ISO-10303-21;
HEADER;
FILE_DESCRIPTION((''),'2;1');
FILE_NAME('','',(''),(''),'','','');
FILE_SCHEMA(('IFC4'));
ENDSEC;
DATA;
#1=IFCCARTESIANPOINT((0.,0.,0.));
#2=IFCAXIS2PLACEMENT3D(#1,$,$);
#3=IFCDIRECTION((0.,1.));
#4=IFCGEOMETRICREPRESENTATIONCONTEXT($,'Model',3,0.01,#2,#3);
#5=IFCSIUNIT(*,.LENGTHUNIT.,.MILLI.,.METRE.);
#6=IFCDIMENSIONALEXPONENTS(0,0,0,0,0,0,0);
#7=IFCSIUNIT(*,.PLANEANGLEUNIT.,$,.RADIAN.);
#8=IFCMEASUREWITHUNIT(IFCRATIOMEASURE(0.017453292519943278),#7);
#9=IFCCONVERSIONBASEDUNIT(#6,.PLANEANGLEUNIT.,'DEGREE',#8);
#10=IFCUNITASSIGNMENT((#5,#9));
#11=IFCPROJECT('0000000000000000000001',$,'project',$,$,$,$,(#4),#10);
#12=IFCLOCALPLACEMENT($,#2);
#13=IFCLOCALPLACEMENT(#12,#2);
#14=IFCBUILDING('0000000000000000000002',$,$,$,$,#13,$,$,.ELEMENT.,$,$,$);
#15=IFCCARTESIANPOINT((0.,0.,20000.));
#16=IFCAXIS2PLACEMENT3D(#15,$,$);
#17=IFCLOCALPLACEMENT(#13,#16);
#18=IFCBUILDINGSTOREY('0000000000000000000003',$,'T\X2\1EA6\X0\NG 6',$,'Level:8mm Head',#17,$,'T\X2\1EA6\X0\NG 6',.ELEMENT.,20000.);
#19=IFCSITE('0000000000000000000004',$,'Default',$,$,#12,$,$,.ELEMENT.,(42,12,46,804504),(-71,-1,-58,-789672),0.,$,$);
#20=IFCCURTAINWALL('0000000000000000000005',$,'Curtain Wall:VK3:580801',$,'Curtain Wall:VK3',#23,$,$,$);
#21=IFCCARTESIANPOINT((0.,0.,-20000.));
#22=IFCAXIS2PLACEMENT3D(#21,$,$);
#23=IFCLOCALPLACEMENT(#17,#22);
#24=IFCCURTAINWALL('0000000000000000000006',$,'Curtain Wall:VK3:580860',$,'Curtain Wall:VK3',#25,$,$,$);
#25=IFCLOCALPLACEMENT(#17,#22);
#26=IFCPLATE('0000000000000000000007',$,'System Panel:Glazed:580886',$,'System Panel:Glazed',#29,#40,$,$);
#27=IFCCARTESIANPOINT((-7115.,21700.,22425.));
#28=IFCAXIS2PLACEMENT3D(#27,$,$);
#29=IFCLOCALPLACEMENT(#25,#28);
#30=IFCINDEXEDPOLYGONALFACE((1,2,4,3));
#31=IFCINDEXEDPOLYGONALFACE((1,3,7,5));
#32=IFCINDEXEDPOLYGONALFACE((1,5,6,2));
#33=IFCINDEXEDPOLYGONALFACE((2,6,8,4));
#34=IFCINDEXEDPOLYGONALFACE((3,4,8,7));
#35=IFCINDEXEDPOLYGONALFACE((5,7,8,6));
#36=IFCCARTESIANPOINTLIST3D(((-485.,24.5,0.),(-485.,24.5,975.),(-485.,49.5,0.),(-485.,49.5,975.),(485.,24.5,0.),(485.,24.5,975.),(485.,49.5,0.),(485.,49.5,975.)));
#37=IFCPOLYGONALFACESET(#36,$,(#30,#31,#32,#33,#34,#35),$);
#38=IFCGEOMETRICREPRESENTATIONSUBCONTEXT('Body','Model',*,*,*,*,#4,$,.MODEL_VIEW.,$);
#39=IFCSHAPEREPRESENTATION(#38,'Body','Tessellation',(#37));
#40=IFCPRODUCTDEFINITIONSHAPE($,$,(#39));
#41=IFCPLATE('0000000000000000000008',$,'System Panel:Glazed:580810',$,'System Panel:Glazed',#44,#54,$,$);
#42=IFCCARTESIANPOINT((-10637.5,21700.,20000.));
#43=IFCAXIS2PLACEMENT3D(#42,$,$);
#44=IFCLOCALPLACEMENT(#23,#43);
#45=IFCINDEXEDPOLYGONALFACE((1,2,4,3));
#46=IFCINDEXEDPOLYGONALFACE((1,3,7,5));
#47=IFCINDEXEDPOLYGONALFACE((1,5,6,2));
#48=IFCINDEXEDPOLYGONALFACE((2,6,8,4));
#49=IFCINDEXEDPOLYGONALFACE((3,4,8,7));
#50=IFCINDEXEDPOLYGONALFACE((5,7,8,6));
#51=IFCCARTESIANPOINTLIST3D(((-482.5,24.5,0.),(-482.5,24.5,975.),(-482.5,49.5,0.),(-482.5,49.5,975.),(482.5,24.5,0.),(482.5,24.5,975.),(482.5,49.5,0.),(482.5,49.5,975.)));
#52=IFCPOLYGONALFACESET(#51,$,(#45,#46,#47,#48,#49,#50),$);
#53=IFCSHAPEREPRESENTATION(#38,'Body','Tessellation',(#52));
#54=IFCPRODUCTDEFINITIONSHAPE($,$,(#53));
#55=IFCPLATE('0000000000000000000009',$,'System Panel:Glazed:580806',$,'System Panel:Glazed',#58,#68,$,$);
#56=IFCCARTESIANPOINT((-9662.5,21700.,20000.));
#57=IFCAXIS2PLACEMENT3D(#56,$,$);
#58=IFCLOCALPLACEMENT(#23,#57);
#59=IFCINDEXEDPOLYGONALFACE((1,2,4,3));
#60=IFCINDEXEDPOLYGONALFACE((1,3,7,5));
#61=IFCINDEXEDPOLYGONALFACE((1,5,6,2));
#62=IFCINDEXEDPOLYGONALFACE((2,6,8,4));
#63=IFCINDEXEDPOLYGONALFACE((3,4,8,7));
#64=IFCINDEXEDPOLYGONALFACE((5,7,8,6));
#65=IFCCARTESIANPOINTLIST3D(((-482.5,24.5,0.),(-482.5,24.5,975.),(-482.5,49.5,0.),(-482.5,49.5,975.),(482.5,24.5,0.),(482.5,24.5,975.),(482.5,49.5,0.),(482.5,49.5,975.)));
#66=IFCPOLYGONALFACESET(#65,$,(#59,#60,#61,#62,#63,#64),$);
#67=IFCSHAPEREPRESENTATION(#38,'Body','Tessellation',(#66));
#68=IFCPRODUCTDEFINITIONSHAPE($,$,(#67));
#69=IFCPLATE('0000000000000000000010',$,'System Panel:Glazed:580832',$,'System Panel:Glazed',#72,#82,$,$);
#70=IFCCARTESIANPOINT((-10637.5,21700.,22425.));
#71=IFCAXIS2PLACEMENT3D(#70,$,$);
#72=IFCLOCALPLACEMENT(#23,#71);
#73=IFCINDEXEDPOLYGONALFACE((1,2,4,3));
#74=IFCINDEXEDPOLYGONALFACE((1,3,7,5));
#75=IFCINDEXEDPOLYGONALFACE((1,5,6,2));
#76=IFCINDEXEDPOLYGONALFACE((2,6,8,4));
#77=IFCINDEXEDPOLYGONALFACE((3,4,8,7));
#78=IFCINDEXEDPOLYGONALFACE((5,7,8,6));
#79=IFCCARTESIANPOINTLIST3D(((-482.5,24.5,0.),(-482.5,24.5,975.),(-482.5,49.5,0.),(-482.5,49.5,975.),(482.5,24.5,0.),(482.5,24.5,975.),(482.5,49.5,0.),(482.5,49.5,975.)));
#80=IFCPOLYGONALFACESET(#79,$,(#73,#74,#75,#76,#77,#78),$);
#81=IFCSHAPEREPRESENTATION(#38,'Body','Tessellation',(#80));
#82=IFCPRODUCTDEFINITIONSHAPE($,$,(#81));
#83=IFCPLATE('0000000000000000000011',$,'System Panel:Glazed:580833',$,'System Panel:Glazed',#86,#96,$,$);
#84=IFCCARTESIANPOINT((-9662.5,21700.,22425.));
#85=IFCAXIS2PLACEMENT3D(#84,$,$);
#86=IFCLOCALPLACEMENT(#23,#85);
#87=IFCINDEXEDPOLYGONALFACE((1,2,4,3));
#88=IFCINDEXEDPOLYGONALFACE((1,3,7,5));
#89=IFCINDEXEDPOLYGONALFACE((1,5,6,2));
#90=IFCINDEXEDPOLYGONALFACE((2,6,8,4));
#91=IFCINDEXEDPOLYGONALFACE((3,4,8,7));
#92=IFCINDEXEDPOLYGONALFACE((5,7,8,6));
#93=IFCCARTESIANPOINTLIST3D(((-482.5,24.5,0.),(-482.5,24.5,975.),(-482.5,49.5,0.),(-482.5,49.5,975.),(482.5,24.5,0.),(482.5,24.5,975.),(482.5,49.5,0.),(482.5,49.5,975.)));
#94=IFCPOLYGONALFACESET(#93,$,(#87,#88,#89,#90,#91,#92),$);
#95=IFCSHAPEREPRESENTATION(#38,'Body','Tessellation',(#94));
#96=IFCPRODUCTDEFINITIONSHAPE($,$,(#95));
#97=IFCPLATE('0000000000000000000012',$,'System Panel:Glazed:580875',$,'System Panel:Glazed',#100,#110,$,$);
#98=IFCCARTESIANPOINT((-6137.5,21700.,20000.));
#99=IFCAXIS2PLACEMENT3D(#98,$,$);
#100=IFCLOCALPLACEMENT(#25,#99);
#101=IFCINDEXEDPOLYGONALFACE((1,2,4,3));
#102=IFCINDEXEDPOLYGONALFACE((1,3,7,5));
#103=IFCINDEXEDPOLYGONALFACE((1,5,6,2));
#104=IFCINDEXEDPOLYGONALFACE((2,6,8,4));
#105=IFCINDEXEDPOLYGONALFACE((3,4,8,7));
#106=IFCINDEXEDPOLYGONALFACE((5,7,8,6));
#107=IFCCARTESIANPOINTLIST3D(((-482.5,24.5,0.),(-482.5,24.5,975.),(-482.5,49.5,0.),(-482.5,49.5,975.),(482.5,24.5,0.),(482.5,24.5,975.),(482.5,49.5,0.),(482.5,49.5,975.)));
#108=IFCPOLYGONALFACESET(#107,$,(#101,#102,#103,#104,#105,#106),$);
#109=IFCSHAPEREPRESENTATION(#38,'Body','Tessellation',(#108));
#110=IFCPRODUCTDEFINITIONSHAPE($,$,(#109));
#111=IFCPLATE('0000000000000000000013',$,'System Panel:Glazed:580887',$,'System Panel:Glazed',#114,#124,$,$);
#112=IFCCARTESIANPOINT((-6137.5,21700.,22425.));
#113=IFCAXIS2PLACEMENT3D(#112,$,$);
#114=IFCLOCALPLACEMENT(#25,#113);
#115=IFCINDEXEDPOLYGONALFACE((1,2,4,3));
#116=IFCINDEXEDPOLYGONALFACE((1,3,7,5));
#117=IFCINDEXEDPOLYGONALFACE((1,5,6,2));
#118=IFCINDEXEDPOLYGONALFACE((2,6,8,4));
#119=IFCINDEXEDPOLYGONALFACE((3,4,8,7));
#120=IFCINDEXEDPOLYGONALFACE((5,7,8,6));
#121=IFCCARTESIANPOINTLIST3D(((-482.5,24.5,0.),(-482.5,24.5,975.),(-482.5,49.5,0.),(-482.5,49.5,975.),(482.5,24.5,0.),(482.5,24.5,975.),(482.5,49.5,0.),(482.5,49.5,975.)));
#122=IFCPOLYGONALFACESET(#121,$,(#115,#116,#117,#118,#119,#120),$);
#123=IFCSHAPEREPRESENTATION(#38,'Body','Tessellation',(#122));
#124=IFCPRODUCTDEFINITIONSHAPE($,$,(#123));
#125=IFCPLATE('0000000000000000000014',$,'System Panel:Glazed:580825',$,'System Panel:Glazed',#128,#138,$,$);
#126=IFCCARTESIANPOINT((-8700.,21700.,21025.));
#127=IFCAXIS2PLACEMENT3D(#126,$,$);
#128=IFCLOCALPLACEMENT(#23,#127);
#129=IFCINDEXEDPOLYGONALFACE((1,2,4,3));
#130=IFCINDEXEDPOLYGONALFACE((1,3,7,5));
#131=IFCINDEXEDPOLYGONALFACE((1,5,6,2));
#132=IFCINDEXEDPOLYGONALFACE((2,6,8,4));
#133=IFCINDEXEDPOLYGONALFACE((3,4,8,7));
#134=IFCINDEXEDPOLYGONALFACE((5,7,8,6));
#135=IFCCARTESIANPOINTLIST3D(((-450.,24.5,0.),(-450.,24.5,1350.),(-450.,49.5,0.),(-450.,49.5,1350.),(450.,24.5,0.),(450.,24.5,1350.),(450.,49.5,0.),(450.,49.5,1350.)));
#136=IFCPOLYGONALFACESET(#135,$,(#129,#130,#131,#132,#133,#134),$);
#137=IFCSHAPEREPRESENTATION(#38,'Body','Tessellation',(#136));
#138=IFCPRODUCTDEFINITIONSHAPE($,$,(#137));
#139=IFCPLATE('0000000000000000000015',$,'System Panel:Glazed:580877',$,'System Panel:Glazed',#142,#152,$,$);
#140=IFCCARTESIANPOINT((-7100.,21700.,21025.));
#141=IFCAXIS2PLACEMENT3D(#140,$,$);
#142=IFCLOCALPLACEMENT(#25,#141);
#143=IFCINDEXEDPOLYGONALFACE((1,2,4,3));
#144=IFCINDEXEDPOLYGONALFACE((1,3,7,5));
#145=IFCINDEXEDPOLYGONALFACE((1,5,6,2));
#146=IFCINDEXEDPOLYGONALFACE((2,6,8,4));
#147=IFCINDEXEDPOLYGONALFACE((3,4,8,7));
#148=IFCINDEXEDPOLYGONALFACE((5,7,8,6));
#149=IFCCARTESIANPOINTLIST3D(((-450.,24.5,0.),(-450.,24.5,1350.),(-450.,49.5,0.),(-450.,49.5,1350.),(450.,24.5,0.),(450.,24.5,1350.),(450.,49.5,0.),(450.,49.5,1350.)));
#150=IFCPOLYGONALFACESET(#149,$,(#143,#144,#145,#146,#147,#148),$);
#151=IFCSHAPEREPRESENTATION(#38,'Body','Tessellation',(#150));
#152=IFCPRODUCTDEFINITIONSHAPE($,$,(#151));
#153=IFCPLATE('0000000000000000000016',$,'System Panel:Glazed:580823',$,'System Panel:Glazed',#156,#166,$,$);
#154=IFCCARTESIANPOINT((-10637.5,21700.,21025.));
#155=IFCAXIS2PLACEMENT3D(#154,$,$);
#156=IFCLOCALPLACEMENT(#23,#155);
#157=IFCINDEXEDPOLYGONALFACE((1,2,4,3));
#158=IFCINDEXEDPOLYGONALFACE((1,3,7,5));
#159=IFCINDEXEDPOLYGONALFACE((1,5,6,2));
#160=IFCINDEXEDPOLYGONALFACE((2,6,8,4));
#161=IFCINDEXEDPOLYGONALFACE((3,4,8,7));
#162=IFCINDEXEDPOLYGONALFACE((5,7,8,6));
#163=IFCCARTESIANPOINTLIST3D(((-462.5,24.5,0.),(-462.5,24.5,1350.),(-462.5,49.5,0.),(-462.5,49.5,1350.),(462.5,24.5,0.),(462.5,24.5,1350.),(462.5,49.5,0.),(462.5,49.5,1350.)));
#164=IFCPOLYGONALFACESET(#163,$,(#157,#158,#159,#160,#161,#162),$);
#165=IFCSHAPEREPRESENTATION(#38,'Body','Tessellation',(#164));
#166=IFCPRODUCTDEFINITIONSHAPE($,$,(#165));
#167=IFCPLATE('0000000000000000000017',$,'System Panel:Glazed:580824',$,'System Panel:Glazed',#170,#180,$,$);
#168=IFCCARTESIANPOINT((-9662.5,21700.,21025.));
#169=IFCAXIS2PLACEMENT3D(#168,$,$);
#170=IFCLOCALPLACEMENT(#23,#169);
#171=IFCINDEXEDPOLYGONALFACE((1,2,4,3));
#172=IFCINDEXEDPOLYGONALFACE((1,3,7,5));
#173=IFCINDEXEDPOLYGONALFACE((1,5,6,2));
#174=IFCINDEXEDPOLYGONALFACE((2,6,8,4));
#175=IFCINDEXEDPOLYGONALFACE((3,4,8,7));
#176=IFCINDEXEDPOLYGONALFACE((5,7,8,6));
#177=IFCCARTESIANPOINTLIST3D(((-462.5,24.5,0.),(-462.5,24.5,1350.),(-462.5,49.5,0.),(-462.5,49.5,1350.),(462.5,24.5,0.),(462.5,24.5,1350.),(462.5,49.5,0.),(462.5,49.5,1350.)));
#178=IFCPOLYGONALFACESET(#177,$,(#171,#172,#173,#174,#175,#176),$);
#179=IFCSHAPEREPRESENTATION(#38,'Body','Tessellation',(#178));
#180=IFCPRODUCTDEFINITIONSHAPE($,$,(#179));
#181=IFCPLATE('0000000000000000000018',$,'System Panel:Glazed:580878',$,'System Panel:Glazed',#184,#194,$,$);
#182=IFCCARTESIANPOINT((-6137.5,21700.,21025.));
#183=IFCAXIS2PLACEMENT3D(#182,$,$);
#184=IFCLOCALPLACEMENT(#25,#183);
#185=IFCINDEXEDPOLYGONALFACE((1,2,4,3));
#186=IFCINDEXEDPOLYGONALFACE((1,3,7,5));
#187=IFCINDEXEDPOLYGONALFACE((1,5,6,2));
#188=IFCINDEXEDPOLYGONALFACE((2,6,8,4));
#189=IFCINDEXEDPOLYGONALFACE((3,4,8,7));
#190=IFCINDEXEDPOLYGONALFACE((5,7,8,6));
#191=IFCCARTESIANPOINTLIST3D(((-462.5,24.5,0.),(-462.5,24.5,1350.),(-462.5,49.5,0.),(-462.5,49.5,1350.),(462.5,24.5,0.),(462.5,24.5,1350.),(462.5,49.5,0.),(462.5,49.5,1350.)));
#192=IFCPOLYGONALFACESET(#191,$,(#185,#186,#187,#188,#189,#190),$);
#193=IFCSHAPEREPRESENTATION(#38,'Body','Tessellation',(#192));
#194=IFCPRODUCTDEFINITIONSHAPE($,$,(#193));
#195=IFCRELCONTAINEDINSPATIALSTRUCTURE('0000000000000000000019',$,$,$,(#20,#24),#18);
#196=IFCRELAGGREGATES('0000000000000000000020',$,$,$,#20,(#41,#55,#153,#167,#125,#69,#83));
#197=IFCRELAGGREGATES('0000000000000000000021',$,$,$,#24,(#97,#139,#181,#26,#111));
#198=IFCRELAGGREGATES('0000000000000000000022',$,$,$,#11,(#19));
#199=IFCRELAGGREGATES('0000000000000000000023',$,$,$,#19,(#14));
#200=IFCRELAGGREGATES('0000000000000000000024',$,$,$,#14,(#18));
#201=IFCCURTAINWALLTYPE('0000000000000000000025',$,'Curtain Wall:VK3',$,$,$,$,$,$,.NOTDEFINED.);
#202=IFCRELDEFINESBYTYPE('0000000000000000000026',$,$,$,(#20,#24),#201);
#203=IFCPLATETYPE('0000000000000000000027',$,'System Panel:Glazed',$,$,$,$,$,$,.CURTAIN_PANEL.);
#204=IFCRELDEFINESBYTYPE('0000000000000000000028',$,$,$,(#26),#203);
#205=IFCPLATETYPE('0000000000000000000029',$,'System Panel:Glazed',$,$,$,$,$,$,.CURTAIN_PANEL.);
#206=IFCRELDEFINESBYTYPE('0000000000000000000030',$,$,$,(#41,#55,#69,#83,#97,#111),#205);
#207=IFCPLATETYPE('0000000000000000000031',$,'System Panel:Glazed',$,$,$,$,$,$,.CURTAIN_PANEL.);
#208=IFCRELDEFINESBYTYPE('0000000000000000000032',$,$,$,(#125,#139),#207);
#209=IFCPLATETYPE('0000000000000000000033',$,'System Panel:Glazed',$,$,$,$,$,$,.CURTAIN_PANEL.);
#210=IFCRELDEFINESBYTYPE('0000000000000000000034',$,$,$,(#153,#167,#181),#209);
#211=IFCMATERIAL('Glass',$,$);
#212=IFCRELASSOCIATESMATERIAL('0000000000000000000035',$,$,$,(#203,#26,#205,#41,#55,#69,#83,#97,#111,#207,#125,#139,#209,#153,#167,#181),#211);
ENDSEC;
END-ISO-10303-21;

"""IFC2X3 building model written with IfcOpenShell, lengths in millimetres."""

from ifc_helpers import new_model, entity, si_unit, converted_unit, direction, frame, origin, origin_2d_with_axis, place, context, subcontext, project, spatial, rectangle, extrude, source, transform, mapped, material, type_object, type_shapes, element, aggregate, save


model = new_model("IFC2X3")

# Units and contexts
model_context = context("Model", 3, precision=0.01, world=origin(), true_north=direction((0.0, 1.0)))
body_context = subcontext(model_context, "Body", "Model", "MODEL_VIEW")
ifc_project = project(units=[si_unit("LENGTHUNIT", "METRE", prefix="MILLI"), converted_unit("PLANEANGLEUNIT", "DEGREE", entity("IfcRatioMeasure", 0.017453292519943278), si_unit("PLANEANGLEUNIT", "RADIAN"), dimensions=[0, 0, 0, 0, 0, 0, 0])], contexts=[model_context])

# Site, building, storey
site_placement = place(None, origin())
site = spatial("IfcSite", under=ifc_project, at=site_placement, Name="Default", CompositionType="ELEMENT", RefLatitude=(42, 12, 46, 804504), RefLongitude=(-71, -1, -58, -789672), RefElevation=0.0)
building_placement = place(site_placement, origin())
building = spatial("IfcBuilding", under=site, at=building_placement, CompositionType="ELEMENT")
storey_placement = place(building_placement, frame((0.0, 0.0, 20000.0)))
storey = spatial("IfcBuildingStorey", under=building, at=storey_placement, Name="TẦNG 6", ObjectType="Level:8mm Head", LongName="TẦNG 6", CompositionType="ELEMENT", Elevation=20000.0)

# Curtain walls
curtain_wall_type_1 = type_object("IfcCurtainWallType", Name="Curtain Wall:VK3", PredefinedType="NOTDEFINED")
curtain_wall_1_placement = place(storey_placement, frame((0.0, 0.0, -20000.0)))
curtain_wall_1 = element("IfcCurtainWall", 1, at=curtain_wall_1_placement, inside=storey, type_object=curtain_wall_type_1, Name="Curtain Wall:VK3:580801", ObjectType="Curtain Wall:VK3")
curtain_wall_2_placement = place(storey_placement, frame((0.0, 0.0, -20000.0)))
curtain_wall_2 = element("IfcCurtainWall", 2, at=curtain_wall_2_placement, inside=storey, type_object=curtain_wall_type_1, Name="Curtain Wall:VK3:580860", ObjectType="Curtain Wall:VK3")

# Shared definitions
ifc_material_1 = material(Name="Glass")

# Plates
plate_type_1 = type_object("IfcPlateType", Name="System Panel:Glazed", PredefinedType="CURTAIN_PANEL", material=ifc_material_1)
shared_shape_1 = source(origin(), body_context, "Body", "SweptSolid", [
    extrude(rectangle(XDim=25.0, YDim=970.0, at=origin_2d_with_axis()), frame((0.0, 37.0, 0.0), z_axis=(0.0, 0.0, 1.0), x_axis=(0.0, 1.0, 0.0)), (0.0, 0.0, 1.0), 975.0),
])
type_shapes(plate_type_1, [shared_shape_1])
plate_1_placement = place(curtain_wall_2_placement, frame((-7115.0, 21700.0, 22425.0)))
plate_1 = element("IfcPlate", 3, at=plate_1_placement, type_object=plate_type_1, material=ifc_material_1, Name="System Panel:Glazed:580886", ObjectType="System Panel:Glazed", context=body_context, shape_type="MappedRepresentation", body=[
    mapped(shared_shape_1, transform((0.0, 0.0, 0.0), scale=1.0)),
])
plate_type_2 = type_object("IfcPlateType", Name="System Panel:Glazed", PredefinedType="CURTAIN_PANEL", material=ifc_material_1)
shared_shape_2 = source(origin(), body_context, "Body", "SweptSolid", [
    extrude(rectangle(XDim=25.0, YDim=965.0, at=origin_2d_with_axis()), frame((0.0, 37.0, 0.0), z_axis=(0.0, 0.0, 1.0), x_axis=(0.0, 1.0, 0.0)), (0.0, 0.0, 1.0), 975.0),
])
type_shapes(plate_type_2, [shared_shape_2])
plate_2_placement = place(curtain_wall_1_placement, frame((-10637.5, 21700.0, 20000.0)))
plate_2 = element("IfcPlate", 4, at=plate_2_placement, type_object=plate_type_2, material=ifc_material_1, Name="System Panel:Glazed:580810", ObjectType="System Panel:Glazed", context=body_context, shape_type="MappedRepresentation", body=[
    mapped(shared_shape_2, transform((0.0, 0.0, 0.0), scale=1.0)),
])
plate_3_placement = place(curtain_wall_1_placement, frame((-9662.5, 21700.0, 20000.0)))
plate_3 = element("IfcPlate", 5, at=plate_3_placement, type_object=plate_type_2, material=ifc_material_1, Name="System Panel:Glazed:580806", ObjectType="System Panel:Glazed", context=body_context, shape_type="MappedRepresentation", body=[
    mapped(shared_shape_2, transform((0.0, 0.0, 0.0), scale=1.0)),
])
plate_4_placement = place(curtain_wall_1_placement, frame((-10637.5, 21700.0, 22425.0)))
plate_4 = element("IfcPlate", 6, at=plate_4_placement, type_object=plate_type_2, material=ifc_material_1, Name="System Panel:Glazed:580832", ObjectType="System Panel:Glazed", context=body_context, shape_type="MappedRepresentation", body=[
    mapped(shared_shape_2, transform((0.0, 0.0, 0.0), scale=1.0)),
])
plate_5_placement = place(curtain_wall_1_placement, frame((-9662.5, 21700.0, 22425.0)))
plate_5 = element("IfcPlate", 7, at=plate_5_placement, type_object=plate_type_2, material=ifc_material_1, Name="System Panel:Glazed:580833", ObjectType="System Panel:Glazed", context=body_context, shape_type="MappedRepresentation", body=[
    mapped(shared_shape_2, transform((0.0, 0.0, 0.0), scale=1.0)),
])
plate_6_placement = place(curtain_wall_2_placement, frame((-6137.5, 21700.0, 20000.0)))
plate_6 = element("IfcPlate", 8, at=plate_6_placement, type_object=plate_type_2, material=ifc_material_1, Name="System Panel:Glazed:580875", ObjectType="System Panel:Glazed", context=body_context, shape_type="MappedRepresentation", body=[
    mapped(shared_shape_2, transform((0.0, 0.0, 0.0), scale=1.0)),
])
plate_7_placement = place(curtain_wall_2_placement, frame((-6137.5, 21700.0, 22425.0)))
plate_7 = element("IfcPlate", 9, at=plate_7_placement, type_object=plate_type_2, material=ifc_material_1, Name="System Panel:Glazed:580887", ObjectType="System Panel:Glazed", context=body_context, shape_type="MappedRepresentation", body=[
    mapped(shared_shape_2, transform((0.0, 0.0, 0.0), scale=1.0)),
])
plate_type_3 = type_object("IfcPlateType", Name="System Panel:Glazed", PredefinedType="CURTAIN_PANEL", material=ifc_material_1)
shared_shape_3 = source(origin(), body_context, "Body", "SweptSolid", [
    extrude(rectangle(XDim=25.0, YDim=900.0, at=origin_2d_with_axis()), frame((0.0, 37.0, 0.0), z_axis=(0.0, 0.0, 1.0), x_axis=(0.0, 1.0, 0.0)), (0.0, 0.0, 1.0), 1350.0),
])
type_shapes(plate_type_3, [shared_shape_3])
plate_8_placement = place(curtain_wall_1_placement, frame((-8700.0, 21700.0, 21025.0)))
plate_8 = element("IfcPlate", 10, at=plate_8_placement, type_object=plate_type_3, material=ifc_material_1, Name="System Panel:Glazed:580825", ObjectType="System Panel:Glazed", context=body_context, shape_type="MappedRepresentation", body=[
    mapped(shared_shape_3, transform((0.0, 0.0, 0.0), scale=1.0)),
])
plate_9_placement = place(curtain_wall_2_placement, frame((-7100.0, 21700.0, 21025.0)))
plate_9 = element("IfcPlate", 11, at=plate_9_placement, type_object=plate_type_3, material=ifc_material_1, Name="System Panel:Glazed:580877", ObjectType="System Panel:Glazed", context=body_context, shape_type="MappedRepresentation", body=[
    mapped(shared_shape_3, transform((0.0, 0.0, 0.0), scale=1.0)),
])
plate_type_4 = type_object("IfcPlateType", Name="System Panel:Glazed", PredefinedType="CURTAIN_PANEL", material=ifc_material_1)
shared_shape_4 = source(origin(), body_context, "Body", "SweptSolid", [
    extrude(rectangle(XDim=25.0, YDim=925.0, at=origin_2d_with_axis()), frame((0.0, 37.0, 0.0), z_axis=(0.0, 0.0, 1.0), x_axis=(0.0, 1.0, 0.0)), (0.0, 0.0, 1.0), 1350.0),
])
type_shapes(plate_type_4, [shared_shape_4])
plate_10_placement = place(curtain_wall_1_placement, frame((-10637.5, 21700.0, 21025.0)))
plate_10 = element("IfcPlate", 12, at=plate_10_placement, type_object=plate_type_4, material=ifc_material_1, Name="System Panel:Glazed:580823", ObjectType="System Panel:Glazed", context=body_context, shape_type="MappedRepresentation", body=[
    mapped(shared_shape_4, transform((0.0, 0.0, 0.0), scale=1.0)),
])
plate_11_placement = place(curtain_wall_1_placement, frame((-9662.5, 21700.0, 21025.0)))
plate_11 = element("IfcPlate", 13, at=plate_11_placement, type_object=plate_type_4, material=ifc_material_1, Name="System Panel:Glazed:580824", ObjectType="System Panel:Glazed", context=body_context, shape_type="MappedRepresentation", body=[
    mapped(shared_shape_4, transform((0.0, 0.0, 0.0), scale=1.0)),
])
aggregate(curtain_wall_1, [plate_2, plate_3, plate_10, plate_11, plate_8, plate_4, plate_5])
plate_12_placement = place(curtain_wall_2_placement, frame((-6137.5, 21700.0, 21025.0)))
plate_12 = element("IfcPlate", 14, at=plate_12_placement, type_object=plate_type_4, material=ifc_material_1, Name="System Panel:Glazed:580878", ObjectType="System Panel:Glazed", context=body_context, shape_type="MappedRepresentation", body=[
    mapped(shared_shape_4, transform((0.0, 0.0, 0.0), scale=1.0)),
])
aggregate(curtain_wall_2, [plate_6, plate_9, plate_12, plate_1, plate_7])

save(model, "model.ifc")
